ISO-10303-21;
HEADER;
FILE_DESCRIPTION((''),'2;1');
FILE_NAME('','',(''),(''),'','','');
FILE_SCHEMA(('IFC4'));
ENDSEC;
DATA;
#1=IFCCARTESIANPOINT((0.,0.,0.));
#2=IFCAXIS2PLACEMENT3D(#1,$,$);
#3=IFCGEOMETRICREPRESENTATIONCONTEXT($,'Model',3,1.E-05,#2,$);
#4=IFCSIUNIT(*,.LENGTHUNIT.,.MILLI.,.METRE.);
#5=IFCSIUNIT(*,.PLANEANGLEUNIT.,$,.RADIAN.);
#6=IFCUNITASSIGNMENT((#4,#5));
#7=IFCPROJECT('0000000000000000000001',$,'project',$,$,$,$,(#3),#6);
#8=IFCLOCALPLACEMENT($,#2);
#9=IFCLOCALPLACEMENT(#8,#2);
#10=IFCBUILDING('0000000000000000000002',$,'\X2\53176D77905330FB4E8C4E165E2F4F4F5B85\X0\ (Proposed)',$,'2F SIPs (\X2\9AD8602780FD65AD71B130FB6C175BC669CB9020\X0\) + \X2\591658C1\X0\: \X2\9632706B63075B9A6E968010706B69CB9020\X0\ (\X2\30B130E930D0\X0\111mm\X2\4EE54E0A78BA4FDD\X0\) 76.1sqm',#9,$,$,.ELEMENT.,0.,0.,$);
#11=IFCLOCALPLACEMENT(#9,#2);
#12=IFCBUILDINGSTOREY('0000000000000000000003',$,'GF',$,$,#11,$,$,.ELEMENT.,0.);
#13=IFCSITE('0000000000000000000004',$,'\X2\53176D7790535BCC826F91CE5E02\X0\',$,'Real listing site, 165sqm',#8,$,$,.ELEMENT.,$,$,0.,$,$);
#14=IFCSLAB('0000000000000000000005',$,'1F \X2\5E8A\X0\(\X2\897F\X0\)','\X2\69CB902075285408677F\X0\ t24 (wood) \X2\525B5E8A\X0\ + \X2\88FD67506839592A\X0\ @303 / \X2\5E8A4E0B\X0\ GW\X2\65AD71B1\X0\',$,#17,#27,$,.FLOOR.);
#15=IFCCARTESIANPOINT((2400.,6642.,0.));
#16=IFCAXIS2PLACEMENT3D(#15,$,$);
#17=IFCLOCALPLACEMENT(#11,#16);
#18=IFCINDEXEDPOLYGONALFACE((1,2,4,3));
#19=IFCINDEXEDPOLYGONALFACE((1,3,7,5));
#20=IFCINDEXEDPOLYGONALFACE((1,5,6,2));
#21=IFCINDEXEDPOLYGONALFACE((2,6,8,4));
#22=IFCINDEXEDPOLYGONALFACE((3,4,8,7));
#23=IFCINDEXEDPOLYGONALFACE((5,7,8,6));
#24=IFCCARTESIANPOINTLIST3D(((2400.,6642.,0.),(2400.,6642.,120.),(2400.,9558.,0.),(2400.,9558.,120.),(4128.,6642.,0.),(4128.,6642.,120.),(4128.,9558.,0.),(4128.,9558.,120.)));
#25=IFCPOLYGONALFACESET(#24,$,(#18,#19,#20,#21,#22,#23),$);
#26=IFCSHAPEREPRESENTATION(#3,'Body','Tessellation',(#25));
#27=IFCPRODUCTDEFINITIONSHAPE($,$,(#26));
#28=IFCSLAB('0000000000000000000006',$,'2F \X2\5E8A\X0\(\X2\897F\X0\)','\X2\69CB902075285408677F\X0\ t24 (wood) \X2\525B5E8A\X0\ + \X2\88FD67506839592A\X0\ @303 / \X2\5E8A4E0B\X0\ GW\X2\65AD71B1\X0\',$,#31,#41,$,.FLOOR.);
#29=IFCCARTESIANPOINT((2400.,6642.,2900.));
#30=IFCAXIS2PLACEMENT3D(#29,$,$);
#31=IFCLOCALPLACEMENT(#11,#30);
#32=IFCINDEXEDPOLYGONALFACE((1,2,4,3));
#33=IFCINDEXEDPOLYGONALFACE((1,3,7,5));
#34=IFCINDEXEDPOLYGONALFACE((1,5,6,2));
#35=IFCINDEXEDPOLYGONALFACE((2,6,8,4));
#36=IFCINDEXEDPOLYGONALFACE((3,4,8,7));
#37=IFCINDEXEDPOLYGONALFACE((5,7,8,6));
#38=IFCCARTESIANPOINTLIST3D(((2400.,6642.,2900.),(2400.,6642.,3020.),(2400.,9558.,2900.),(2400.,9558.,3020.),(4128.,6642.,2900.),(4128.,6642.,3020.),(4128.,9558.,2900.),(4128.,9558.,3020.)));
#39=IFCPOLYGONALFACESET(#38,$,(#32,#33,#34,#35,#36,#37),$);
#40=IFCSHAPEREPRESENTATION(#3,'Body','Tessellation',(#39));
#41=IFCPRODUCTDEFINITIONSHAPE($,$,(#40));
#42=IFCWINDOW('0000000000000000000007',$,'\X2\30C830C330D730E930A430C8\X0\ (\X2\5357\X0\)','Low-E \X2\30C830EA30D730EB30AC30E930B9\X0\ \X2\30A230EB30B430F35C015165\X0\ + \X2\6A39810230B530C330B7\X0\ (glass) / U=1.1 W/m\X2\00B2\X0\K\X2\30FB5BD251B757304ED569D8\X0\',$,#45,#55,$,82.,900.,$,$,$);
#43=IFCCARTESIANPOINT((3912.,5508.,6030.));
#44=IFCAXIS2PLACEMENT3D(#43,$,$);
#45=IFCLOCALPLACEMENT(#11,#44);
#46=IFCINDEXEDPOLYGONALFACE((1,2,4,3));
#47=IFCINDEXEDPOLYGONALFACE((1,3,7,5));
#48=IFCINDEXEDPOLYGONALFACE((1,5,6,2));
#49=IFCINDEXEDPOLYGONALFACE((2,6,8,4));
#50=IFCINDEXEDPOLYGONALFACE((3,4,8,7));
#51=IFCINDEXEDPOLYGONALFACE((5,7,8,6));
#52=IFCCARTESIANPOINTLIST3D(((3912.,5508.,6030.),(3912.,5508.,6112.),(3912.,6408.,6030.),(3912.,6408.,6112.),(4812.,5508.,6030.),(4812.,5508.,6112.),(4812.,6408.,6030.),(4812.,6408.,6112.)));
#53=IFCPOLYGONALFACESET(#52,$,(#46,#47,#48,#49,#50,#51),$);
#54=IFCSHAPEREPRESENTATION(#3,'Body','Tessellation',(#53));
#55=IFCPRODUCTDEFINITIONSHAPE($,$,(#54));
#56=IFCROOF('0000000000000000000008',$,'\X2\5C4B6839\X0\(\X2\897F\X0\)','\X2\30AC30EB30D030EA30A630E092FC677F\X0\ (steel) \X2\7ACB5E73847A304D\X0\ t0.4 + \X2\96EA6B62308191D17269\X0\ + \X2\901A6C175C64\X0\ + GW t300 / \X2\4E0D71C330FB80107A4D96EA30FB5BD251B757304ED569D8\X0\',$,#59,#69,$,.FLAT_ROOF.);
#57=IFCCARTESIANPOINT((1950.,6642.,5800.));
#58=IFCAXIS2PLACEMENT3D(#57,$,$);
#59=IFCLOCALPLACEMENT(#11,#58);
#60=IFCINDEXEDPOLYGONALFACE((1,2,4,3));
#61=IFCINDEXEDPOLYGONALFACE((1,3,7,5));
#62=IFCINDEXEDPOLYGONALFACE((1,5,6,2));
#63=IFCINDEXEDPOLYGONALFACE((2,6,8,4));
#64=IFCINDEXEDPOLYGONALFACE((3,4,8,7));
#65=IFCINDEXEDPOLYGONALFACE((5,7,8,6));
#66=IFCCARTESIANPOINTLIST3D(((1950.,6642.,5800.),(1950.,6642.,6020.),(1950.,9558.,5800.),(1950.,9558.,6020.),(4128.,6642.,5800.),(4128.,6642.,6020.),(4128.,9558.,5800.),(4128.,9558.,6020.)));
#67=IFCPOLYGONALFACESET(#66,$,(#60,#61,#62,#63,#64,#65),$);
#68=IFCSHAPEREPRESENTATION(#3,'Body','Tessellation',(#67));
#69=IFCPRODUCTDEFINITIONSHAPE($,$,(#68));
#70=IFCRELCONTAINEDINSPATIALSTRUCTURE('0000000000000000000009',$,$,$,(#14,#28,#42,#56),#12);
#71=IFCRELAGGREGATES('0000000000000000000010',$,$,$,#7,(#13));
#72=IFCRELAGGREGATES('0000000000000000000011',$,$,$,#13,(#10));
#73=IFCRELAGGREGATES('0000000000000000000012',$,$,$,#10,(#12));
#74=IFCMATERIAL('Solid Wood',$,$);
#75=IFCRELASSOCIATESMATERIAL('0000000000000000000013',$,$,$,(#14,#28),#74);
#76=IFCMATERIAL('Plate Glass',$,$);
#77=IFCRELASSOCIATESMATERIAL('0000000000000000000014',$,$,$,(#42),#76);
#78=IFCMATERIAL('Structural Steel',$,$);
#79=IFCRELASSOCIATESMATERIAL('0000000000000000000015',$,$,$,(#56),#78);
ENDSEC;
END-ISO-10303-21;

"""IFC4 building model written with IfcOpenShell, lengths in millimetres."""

from ifc_helpers import new_model, si_unit, frame, frame_2d, origin, place, context, project, spatial, rectangle, extrude, material, element, save


model = new_model("IFC4")

# Units and contexts
model_context = context("Model", 3, precision=1e-05, world=origin())
ifc_project = project(units=[si_unit("LENGTHUNIT", "METRE", prefix="MILLI"), si_unit("PLANEANGLEUNIT", "RADIAN")], contexts=[model_context])

# Site, building, storey
site_placement = place(None, origin())
site = spatial("IfcSite", under=ifc_project, at=site_placement, Name="北海道富良野市", ObjectType="Real listing site, 165sqm", CompositionType="ELEMENT", RefElevation=0.0)
building_placement = place(site_placement, origin())
building = spatial("IfcBuilding", under=site, at=building_placement, Name="北海道・二世帯住宅 (Proposed)", ObjectType="2F SIPs (高性能断熱・気密構造) + 外壁: 防火指定準耐火構造 (ケラバ111mm以上確保) 76.1sqm", CompositionType="ELEMENT", ElevationOfRefHeight=0.0, ElevationOfTerrain=0.0)
storey_placement = place(building_placement, origin())
storey = spatial("IfcBuildingStorey", under=building, at=storey_placement, Name="GF", CompositionType="ELEMENT", Elevation=0.0)

# Shared definitions
ifc_material_1 = material(Name="Solid Wood")

# Slabs
slab_1_placement = place(storey_placement, frame((2400.0, 6642.0, 0.0)))
element("IfcSlab", 1, at=slab_1_placement, inside=storey, material=ifc_material_1, Name="1F 床(西)", Description="構造用合板 t24 (wood) 剛床 + 製材根太 @303 / 床下 GW断熱", PredefinedType="FLOOR", context=model_context, shape_type="SweptSolid", body=[
    extrude(rectangle(XDim=1728.0, YDim=2916.0, at=frame_2d((864.0, 1458.0))), frame((2400.0, 6642.0, 0.0)), (0.0, 0.0, 1.0), 120.0),
])
slab_2_placement = place(storey_placement, frame((2400.0, 6642.0, 2900.0)))
element("IfcSlab", 2, at=slab_2_placement, inside=storey, material=ifc_material_1, Name="2F 床(西)", Description="構造用合板 t24 (wood) 剛床 + 製材根太 @303 / 床下 GW断熱", PredefinedType="FLOOR", context=model_context, shape_type="SweptSolid", body=[
    extrude(rectangle(XDim=1728.0, YDim=2916.0, at=frame_2d((864.0, 1458.0))), frame((2400.0, 6642.0, 2900.0)), (0.0, 0.0, 1.0), 120.0),
])

# Window
ifc_material_2 = material(Name="Plate Glass")
window_placement = place(storey_placement, frame((3912.0, 5508.0, 6030.0)))
element("IfcWindow", 3, at=window_placement, inside=storey, material=ifc_material_2, Name="トップライト (南)", Description="Low-E トリプルガラス アルゴン封入 + 樹脂サッシ (glass) / U=1.1 W/m²K・寒冷地仕様", OverallHeight=82.0, OverallWidth=900.0, context=model_context, shape_type="SweptSolid", body=[
    extrude(rectangle(XDim=900.0, YDim=900.0, at=frame_2d((450.0, 450.0))), frame((3912.0, 5508.0, 6030.0)), (0.0, 0.0, 1.0), 82.0),
])

# Roof
ifc_material_3 = material(Name="Structural Steel")
for number, where, name in (
    (4, (1950.0, 6642.0, 5800.0), "屋根(西)"),
):
    element("IfcRoof", number, at=place(storey_placement, frame(where)), inside=storey, material=ifc_material_3, Name=name, Description="ガルバリウム鋼板 (steel) 立平葺き t0.4 + 雪止め金物 + 通気層 + GW t300 / 不燃・耐積雪・寒冷地仕様", PredefinedType="FLAT_ROOF", context=model_context, shape_type="SweptSolid", body=[
        extrude(rectangle(XDim=2178.0, YDim=2916.0, at=frame_2d((1089.0, 1458.0))), frame((1950.0, 6642.0, 5800.0)), (0.0, 0.0, 1.0), 220.0),
    ])

save(model, "model.ifc")
